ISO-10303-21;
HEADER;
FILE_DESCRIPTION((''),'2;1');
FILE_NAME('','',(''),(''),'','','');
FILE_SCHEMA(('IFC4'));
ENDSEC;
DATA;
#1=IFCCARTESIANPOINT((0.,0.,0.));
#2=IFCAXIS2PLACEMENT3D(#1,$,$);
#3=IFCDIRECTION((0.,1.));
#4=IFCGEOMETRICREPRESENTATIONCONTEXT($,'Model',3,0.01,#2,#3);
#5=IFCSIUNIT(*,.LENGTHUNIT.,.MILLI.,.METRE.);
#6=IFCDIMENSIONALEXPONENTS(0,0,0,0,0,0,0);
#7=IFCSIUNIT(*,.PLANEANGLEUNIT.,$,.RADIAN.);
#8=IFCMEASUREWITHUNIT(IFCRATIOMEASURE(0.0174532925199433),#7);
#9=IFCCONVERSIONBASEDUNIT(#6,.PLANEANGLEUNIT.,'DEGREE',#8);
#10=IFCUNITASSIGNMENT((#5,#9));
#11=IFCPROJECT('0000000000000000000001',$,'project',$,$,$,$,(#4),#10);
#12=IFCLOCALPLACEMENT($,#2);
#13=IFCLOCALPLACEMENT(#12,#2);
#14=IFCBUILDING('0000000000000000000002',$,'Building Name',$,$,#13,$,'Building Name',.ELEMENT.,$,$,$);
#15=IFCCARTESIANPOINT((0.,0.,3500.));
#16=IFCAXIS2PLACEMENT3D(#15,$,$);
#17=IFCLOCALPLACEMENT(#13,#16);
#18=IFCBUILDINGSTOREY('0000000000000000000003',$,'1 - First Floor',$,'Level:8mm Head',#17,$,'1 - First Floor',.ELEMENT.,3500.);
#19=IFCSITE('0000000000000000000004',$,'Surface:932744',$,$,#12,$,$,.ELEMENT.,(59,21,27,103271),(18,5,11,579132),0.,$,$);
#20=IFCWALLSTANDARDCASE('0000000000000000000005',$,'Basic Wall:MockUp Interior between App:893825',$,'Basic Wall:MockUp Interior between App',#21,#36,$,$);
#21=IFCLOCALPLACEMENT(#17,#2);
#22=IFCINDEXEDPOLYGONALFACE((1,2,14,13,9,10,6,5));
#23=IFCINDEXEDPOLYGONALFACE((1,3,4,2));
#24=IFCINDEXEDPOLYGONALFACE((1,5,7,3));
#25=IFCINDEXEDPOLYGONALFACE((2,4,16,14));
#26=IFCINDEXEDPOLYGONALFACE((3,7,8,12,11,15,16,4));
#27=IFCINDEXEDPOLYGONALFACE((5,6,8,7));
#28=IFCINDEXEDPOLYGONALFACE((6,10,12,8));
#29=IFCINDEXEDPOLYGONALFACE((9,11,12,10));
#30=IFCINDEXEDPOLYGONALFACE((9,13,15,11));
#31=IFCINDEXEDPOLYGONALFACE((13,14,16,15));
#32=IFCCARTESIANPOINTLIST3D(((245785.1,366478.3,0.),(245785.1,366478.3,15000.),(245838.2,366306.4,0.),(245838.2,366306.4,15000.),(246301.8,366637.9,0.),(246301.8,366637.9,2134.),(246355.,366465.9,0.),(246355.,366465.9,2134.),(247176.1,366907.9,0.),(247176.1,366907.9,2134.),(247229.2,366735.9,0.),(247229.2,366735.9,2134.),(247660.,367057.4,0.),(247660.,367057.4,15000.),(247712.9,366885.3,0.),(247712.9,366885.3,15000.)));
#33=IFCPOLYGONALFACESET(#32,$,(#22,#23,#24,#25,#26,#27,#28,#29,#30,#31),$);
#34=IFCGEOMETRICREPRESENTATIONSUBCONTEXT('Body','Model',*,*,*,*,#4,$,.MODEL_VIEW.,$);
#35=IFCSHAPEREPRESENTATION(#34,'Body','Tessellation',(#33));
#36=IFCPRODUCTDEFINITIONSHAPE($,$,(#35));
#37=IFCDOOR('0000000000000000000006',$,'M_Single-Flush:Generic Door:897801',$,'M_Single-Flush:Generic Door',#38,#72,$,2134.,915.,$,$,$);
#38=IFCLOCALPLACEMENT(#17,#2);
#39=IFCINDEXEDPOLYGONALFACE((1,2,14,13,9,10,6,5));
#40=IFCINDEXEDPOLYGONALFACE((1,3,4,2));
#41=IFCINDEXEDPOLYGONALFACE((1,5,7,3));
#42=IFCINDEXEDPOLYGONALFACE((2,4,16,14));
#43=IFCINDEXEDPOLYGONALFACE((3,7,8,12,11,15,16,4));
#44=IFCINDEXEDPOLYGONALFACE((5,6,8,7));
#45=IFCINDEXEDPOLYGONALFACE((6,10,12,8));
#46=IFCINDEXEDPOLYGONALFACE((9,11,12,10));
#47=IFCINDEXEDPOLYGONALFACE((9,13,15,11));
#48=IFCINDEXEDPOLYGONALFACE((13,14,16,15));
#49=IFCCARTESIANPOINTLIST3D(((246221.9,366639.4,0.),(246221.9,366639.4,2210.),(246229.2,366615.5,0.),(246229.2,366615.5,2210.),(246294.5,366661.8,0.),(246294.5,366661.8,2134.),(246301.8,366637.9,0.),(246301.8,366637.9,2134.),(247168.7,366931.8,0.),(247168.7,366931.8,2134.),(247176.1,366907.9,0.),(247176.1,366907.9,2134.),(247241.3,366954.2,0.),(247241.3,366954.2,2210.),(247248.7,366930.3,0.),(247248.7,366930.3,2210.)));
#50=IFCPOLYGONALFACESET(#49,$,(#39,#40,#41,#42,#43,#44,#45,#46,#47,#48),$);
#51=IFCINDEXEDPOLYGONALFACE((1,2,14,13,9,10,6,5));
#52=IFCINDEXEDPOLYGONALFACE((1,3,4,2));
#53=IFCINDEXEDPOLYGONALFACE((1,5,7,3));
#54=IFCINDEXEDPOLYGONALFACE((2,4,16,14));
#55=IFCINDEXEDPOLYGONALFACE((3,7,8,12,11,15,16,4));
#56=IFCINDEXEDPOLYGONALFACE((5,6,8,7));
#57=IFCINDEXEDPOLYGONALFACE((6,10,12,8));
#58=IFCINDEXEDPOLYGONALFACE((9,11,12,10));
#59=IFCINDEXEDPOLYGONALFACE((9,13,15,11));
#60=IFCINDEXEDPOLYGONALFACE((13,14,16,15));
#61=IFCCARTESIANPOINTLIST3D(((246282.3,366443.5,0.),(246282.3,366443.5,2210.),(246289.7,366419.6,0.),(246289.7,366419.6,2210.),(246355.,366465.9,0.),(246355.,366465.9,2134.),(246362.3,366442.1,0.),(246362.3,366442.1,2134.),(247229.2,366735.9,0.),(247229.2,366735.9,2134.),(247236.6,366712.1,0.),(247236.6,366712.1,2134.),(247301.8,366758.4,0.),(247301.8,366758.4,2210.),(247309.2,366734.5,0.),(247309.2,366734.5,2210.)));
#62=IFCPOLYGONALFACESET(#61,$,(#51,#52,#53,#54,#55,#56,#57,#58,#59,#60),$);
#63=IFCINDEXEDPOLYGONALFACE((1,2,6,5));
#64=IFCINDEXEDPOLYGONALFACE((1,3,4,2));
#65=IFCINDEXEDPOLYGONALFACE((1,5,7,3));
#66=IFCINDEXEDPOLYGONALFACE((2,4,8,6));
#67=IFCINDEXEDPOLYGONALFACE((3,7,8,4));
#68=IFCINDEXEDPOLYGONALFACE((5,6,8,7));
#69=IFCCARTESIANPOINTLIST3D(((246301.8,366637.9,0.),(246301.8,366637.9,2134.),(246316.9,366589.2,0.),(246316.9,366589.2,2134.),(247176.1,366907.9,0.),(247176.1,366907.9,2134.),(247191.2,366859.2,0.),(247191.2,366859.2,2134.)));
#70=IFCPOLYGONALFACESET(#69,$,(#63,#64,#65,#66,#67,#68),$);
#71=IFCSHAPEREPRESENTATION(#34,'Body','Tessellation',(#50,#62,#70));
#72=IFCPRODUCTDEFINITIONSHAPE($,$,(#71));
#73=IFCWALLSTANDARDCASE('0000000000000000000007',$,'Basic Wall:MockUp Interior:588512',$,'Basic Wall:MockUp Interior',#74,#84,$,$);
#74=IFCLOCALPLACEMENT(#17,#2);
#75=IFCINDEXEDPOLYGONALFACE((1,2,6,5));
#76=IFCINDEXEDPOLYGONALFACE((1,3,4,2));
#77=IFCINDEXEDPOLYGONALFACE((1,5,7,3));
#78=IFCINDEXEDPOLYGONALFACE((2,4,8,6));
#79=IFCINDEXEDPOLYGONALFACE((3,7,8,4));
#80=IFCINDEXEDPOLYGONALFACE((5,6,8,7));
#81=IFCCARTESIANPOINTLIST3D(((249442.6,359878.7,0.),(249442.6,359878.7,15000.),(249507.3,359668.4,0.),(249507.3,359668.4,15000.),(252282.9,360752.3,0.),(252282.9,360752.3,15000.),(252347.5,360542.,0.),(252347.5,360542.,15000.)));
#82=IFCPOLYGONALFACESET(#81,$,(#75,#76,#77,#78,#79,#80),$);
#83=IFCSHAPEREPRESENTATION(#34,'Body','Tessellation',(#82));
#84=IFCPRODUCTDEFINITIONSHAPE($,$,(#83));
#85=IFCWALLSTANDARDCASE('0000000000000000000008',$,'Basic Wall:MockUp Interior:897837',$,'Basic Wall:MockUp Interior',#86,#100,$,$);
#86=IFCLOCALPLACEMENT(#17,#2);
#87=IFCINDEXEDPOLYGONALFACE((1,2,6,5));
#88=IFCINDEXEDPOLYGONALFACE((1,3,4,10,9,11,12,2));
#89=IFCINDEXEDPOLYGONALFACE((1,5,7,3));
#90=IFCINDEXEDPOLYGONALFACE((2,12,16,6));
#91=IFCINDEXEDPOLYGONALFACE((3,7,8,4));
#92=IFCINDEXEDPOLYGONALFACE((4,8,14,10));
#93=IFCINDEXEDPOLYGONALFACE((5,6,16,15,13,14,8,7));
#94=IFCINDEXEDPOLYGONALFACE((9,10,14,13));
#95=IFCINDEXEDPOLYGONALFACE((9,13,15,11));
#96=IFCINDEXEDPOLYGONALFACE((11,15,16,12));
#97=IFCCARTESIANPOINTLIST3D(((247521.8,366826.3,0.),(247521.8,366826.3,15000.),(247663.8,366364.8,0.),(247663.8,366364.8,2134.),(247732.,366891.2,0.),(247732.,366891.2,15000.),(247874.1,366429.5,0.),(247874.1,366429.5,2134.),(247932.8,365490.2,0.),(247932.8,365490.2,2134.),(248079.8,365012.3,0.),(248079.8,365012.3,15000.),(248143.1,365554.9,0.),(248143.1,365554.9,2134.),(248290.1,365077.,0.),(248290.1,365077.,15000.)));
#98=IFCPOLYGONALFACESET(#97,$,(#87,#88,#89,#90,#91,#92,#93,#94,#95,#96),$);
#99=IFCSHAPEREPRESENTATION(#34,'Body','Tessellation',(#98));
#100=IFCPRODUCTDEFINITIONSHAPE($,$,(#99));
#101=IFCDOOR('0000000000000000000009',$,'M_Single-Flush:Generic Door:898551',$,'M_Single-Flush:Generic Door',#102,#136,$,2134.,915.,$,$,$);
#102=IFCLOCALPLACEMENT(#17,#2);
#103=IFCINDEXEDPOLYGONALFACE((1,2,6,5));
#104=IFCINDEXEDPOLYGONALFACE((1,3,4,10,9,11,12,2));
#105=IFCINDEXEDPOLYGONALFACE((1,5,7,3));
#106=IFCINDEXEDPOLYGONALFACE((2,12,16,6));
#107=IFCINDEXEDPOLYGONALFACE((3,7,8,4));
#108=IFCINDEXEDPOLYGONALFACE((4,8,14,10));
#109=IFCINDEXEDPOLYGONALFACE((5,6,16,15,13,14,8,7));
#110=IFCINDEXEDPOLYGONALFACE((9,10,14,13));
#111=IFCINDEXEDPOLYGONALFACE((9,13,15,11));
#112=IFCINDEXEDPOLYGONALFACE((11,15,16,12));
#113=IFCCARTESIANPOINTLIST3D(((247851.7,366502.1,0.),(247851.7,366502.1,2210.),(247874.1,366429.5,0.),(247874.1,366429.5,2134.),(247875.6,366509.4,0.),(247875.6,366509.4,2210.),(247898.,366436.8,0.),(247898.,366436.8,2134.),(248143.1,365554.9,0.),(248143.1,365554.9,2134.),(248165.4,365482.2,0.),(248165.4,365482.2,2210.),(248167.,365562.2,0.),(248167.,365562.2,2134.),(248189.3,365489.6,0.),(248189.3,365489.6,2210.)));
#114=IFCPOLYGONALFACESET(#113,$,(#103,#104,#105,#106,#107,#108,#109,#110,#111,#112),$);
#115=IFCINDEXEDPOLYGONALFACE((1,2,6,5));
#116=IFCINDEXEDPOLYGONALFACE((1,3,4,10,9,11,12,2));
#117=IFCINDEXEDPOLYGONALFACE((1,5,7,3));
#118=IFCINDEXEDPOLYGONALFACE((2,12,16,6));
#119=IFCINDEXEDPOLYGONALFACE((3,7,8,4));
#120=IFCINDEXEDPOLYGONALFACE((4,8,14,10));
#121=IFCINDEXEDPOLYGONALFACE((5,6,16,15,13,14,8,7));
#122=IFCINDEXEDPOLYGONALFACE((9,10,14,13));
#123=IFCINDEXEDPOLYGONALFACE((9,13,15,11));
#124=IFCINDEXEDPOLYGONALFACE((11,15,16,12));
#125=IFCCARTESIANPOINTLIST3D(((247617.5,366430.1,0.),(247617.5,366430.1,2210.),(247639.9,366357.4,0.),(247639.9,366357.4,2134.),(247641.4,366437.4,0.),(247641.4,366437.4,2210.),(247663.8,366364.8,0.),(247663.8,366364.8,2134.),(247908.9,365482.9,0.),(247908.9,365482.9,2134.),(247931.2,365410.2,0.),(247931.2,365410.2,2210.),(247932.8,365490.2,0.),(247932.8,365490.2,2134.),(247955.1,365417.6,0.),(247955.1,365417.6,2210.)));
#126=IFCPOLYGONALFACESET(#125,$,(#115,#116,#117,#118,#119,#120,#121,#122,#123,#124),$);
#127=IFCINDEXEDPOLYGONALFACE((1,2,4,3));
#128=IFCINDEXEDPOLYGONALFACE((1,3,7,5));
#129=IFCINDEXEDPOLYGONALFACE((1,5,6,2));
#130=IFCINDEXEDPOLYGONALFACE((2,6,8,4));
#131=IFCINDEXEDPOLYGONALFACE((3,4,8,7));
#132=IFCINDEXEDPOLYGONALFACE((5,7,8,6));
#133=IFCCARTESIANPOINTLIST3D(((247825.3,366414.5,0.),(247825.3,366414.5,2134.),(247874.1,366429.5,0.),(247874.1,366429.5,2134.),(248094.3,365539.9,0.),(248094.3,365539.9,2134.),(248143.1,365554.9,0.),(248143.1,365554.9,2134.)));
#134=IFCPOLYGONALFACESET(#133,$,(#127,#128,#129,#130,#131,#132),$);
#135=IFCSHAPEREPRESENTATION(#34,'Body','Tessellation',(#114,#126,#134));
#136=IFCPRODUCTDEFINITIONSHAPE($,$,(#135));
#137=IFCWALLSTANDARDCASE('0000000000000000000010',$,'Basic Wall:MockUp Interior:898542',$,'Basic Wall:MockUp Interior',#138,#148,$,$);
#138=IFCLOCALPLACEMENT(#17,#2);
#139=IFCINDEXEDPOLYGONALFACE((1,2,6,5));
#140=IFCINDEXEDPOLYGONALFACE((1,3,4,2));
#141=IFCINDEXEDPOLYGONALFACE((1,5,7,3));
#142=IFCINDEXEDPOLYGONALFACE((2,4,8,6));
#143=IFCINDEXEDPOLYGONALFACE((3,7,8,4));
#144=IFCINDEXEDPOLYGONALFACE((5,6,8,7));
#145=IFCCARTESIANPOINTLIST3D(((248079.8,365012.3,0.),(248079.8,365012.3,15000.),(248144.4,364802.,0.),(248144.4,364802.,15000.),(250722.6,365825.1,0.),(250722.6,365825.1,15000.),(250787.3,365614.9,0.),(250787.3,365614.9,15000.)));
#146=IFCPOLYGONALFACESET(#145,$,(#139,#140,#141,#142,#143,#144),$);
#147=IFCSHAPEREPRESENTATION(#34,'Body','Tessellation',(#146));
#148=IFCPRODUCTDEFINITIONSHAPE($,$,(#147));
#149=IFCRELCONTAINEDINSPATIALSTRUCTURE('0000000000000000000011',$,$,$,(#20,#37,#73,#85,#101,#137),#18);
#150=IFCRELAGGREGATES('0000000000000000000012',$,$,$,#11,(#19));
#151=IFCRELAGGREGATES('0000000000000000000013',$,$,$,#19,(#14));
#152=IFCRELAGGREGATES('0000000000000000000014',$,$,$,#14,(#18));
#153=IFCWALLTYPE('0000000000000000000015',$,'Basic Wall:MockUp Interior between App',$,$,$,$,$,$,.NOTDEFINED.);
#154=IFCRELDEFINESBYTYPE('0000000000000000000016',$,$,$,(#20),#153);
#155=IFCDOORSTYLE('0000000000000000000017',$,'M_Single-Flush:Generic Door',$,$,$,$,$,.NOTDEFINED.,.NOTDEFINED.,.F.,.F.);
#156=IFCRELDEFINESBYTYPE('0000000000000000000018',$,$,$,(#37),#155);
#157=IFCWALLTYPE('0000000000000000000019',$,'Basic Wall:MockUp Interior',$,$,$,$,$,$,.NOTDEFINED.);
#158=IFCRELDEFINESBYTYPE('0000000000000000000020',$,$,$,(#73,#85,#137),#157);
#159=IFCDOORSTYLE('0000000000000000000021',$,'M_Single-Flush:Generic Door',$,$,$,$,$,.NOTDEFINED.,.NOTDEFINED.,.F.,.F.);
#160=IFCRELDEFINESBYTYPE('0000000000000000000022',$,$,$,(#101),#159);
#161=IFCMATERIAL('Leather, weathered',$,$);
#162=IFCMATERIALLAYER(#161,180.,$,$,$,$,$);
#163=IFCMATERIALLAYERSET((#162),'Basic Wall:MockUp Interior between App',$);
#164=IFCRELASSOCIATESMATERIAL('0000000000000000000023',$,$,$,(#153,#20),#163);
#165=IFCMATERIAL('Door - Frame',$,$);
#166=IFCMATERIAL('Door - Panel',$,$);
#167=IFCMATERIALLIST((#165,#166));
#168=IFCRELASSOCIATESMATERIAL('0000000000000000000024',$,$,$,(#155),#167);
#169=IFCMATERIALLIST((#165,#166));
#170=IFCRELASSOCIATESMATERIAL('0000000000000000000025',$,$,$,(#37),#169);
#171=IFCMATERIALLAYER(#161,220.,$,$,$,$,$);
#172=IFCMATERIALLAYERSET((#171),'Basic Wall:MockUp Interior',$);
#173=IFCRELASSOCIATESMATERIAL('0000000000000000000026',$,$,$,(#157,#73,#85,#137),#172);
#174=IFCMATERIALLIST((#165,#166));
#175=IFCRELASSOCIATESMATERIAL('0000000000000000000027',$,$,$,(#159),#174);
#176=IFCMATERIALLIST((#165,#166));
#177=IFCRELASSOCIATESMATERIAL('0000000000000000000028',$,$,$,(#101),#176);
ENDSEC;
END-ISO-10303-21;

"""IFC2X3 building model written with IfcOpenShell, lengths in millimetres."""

from ifc_helpers import new_model, entity, si_unit, converted_unit, direction, frame, frame_2d, origin, place, context, subcontext, project, spatial, polyline, rectangle, outline, extrude, source, transform, mapped, material, material_list, layer, layer_set, layer_usage, type_object, type_shapes, element, fill, save


model = new_model("IFC2X3")

# Units and contexts
model_context = context("Model", 3, precision=0.01, world=origin(), true_north=direction((0.0, 1.0)))
body_context = subcontext(model_context, "Body", "Model", "MODEL_VIEW")
ifc_project = project(units=[si_unit("LENGTHUNIT", "METRE", prefix="MILLI"), converted_unit("PLANEANGLEUNIT", "DEGREE", entity("IfcRatioMeasure", 0.0174532925199433), si_unit("PLANEANGLEUNIT", "RADIAN"), dimensions=[0, 0, 0, 0, 0, 0, 0])], contexts=[model_context])

# Site, building, storey
site_placement = place(None, origin())
site = spatial("IfcSite", under=ifc_project, at=site_placement, Name="Surface:932744", CompositionType="ELEMENT", RefLatitude=(59, 21, 27, 103271), RefLongitude=(18, 5, 11, 579132), RefElevation=0.0)
building_placement = place(site_placement, origin())
building = spatial("IfcBuilding", under=site, at=building_placement, Name="Building Name", LongName="Building Name", CompositionType="ELEMENT")
storey_placement = place(building_placement, frame((0.0, 0.0, 3500.0)))
storey = spatial("IfcBuildingStorey", under=building, at=storey_placement, Name="1 - First Floor", ObjectType="Level:8mm Head", LongName="1 - First Floor", CompositionType="ELEMENT", Elevation=3500.0)

# Wall, opening, door
ifc_material_1 = material(Name="Leather, weathered")
ifc_layer_1 = layer(ifc_material_1, 180.0)
ifc_layer_set_1 = layer_set([ifc_layer_1], Name="Basic Wall:MockUp Interior between App")
ifc_layer_usage_1 = layer_usage(ifc_layer_set_1, "AXIS2", "NEGATIVE", 90.0)
wall_type_1 = type_object("IfcWallType", Name="Basic Wall:MockUp Interior between App", PredefinedType="NOTDEFINED", material=ifc_layer_set_1)
wall_1_placement = place(storey_placement, frame((245811.7, 366392.3, 0.0), z_axis=(0.0, 0.0, 1.0), x_axis=(0.955473, 0.29508, 0.0)))
wall_1 = element("IfcWallStandardCase", 1, at=wall_1_placement, inside=storey, type_object=wall_type_1, material=ifc_layer_usage_1, Name="Basic Wall:MockUp Interior between App:893825", ObjectType="Basic Wall:MockUp Interior between App", context=body_context, shape_type="SweptSolid", body=[
    extrude(outline(polyline([(0.0, -90.0), (1762.1, -90.0), (1962.1, -90.0), (1962.3, 90.0), (1782.3, 90.0), (0.0, 90.0), (0.0, -90.0)])), origin(), (0.0, 0.0, 1.0), 15000.0),
])
opening_1_placement = place(wall_1_placement, frame((540.8, -90.0, 0.0)))
opening_1 = element("IfcOpeningElement", 2, at=opening_1_placement, cuts=wall_1, ObjectType="Opening", context=body_context, shape_type="SweptSolid", body=[
    extrude(rectangle(XDim=915.0, YDim=2134.0, at=frame_2d((1067.0, 457.5), x_axis=(0.0, 1.0))), frame((0.0, 0.0, 0.0), z_axis=(0.0, 1.0, 0.0), x_axis=(0.0, 0.0, 1.0)), (0.0, 0.0, 1.0), 180.0),
])
ifc_material_2 = material(Name="Door - Frame")
ifc_material_3 = material(Name="Door - Panel")
ifc_material_list_1 = material_list([ifc_material_2, ifc_material_3])
ifc_material_list_2 = material_list([ifc_material_2, ifc_material_3])
door_style_1 = type_object("IfcDoorStyle", Name="M_Single-Flush:Generic Door", ConstructionType="NOTDEFINED", OperationType="NOTDEFINED", ParameterTakesPrecedence=False, Sizeable=False, material=ifc_material_list_2)
shared_shape_1 = source(origin(), body_context, "Body", "SweptSolid", [
    extrude(outline(polyline([(-533.5, -1124.0), (533.5, -1124.0), (533.5, 1086.0), (457.5, 1086.0), (457.5, -1048.0), (-457.5, -1048.0), (-457.5, 1086.0), (-533.5, 1086.0), (-533.5, -1124.0)])), frame((457.5, 180.0, 1086.0), z_axis=(0.0, 1.0, 0.0), x_axis=(1.0, 0.0, 0.0)), (0.0, 0.0, 1.0), 25.0),
    extrude(outline(polyline([(-1124.0, -533.5), (1086.0, -533.5), (1086.0, -457.5), (-1048.0, -457.5), (-1048.0, 457.5), (1086.0, 457.5), (1086.0, 533.5), (-1124.0, 533.5), (-1124.0, -533.5)])), frame((457.5, -25.0, 1086.0), z_axis=(0.0, 1.0, 0.0), x_axis=(0.0, 0.0, -1.0)), (0.0, 0.0, 1.0), 25.0),
    extrude(rectangle(XDim=51.0, YDim=915.0, at=frame_2d((0.0, 0.0), x_axis=(1.0, 0.0))), frame((457.5, 154.5, 0.0), z_axis=(0.0, 0.0, 1.0), x_axis=(0.0, 1.0, 0.0)), (0.0, 0.0, 1.0), 2134.0),
])
type_shapes(door_style_1, [shared_shape_1])
door_1_placement = place(opening_1_placement, origin())
door_1 = element("IfcDoor", 3, at=door_1_placement, inside=storey, type_object=door_style_1, material=ifc_material_list_1, Name="M_Single-Flush:Generic Door:897801", ObjectType="M_Single-Flush:Generic Door", OverallHeight=2134.0, OverallWidth=915.0, context=body_context, shape_type="MappedRepresentation", body=[
    mapped(shared_shape_1, transform((0.0, 0.0, 0.0), scale=1.0)),
])
fill(opening_1, door_1)

# Wall
ifc_layer_2 = layer(ifc_material_1, 220.0)
ifc_layer_set_2 = layer_set([ifc_layer_2], Name="Basic Wall:MockUp Interior")
ifc_layer_usage_2 = layer_usage(ifc_layer_set_2, "AXIS2", "NEGATIVE", 110.0)
wall_type_2 = type_object("IfcWallType", Name="Basic Wall:MockUp Interior", PredefinedType="NOTDEFINED", material=ifc_layer_set_2)
wall_2_placement = place(storey_placement, frame((249475.0, 359773.6, 0.0), z_axis=(0.0, 0.0, 1.0), x_axis=(0.955811, 0.29398, 0.0)))
element("IfcWallStandardCase", 4, at=wall_2_placement, inside=storey, type_object=wall_type_2, material=ifc_layer_usage_2, Name="Basic Wall:MockUp Interior:588512", ObjectType="Basic Wall:MockUp Interior", context=body_context, shape_type="SweptSolid", body=[
    extrude(rectangle(XDim=2971.5, YDim=220.0, at=frame_2d((1485.8, 0.0), x_axis=(-1.0, 0.0))), origin(), (0.0, 0.0, 1.0), 15000.0),
])

# Wall, opening, door
ifc_layer_usage_3 = layer_usage(ifc_layer_set_2, "AXIS2", "NEGATIVE", 110.0)
wall_3_placement = place(storey_placement, frame((247626.9, 366858.9, 0.0), z_axis=(0.0, 0.0, 1.0), x_axis=(0.29398, -0.955811, 0.0)))
wall_3 = element("IfcWallStandardCase", 5, at=wall_3_placement, inside=storey, type_object=wall_type_2, material=ifc_layer_usage_3, Name="Basic Wall:MockUp Interior:897837", ObjectType="Basic Wall:MockUp Interior", context=body_context, shape_type="SweptSolid", body=[
    extrude(outline(polyline([(0.3, -110.0), (1898.1, -110.0), (1898.1, 110.0), (0.0, 110.0), (0.0, 90.0), (0.3, -110.0)])), origin(), (0.0, 0.0, 1.0), 15000.0),
])
opening_2_placement = place(wall_3_placement, frame((483.1, -110.0, 0.0)))
opening_2 = element("IfcOpeningElement", 6, at=opening_2_placement, cuts=wall_3, ObjectType="Opening", context=body_context, shape_type="SweptSolid", body=[
    extrude(rectangle(XDim=915.0, YDim=2134.0, at=frame_2d((1067.0, 457.5), x_axis=(0.0, 1.0))), frame((0.0, 0.0, 0.0), z_axis=(0.0, 1.0, 0.0), x_axis=(0.0, 0.0, 1.0)), (0.0, 0.0, 1.0), 220.0),
])
ifc_material_list_3 = material_list([ifc_material_2, ifc_material_3])
ifc_material_list_4 = material_list([ifc_material_2, ifc_material_3])
door_style_2 = type_object("IfcDoorStyle", Name="M_Single-Flush:Generic Door", ConstructionType="NOTDEFINED", OperationType="NOTDEFINED", ParameterTakesPrecedence=False, Sizeable=False, material=ifc_material_list_4)
shared_shape_2 = source(origin(), body_context, "Body", "SweptSolid", [
    extrude(outline(polyline([(-533.5, -1124.0), (533.5, -1124.0), (533.5, 1086.0), (457.5, 1086.0), (457.5, -1048.0), (-457.5, -1048.0), (-457.5, 1086.0), (-533.5, 1086.0), (-533.5, -1124.0)])), frame((457.5, 220.0, 1086.0), z_axis=(0.0, 1.0, 0.0), x_axis=(1.0, 0.0, 0.0)), (0.0, 0.0, 1.0), 25.0),
    extrude(outline(polyline([(-1124.0, -533.5), (1086.0, -533.5), (1086.0, -457.5), (-1048.0, -457.5), (-1048.0, 457.5), (1086.0, 457.5), (1086.0, 533.5), (-1124.0, 533.5), (-1124.0, -533.5)])), frame((457.5, -25.0, 1086.0), z_axis=(0.0, 1.0, 0.0), x_axis=(0.0, 0.0, -1.0)), (0.0, 0.0, 1.0), 25.0),
    extrude(rectangle(XDim=51.0, YDim=915.0, at=frame_2d((0.0, 0.0), x_axis=(1.0, 0.0))), frame((457.5, 194.5, 0.0), z_axis=(0.0, 0.0, 1.0), x_axis=(0.0, 1.0, 0.0)), (0.0, 0.0, 1.0), 2134.0),
])
type_shapes(door_style_2, [shared_shape_2])
door_2_placement = place(opening_2_placement, origin())
door_2 = element("IfcDoor", 7, at=door_2_placement, inside=storey, type_object=door_style_2, material=ifc_material_list_3, Name="M_Single-Flush:Generic Door:898551", ObjectType="M_Single-Flush:Generic Door", OverallHeight=2134.0, OverallWidth=915.0, context=body_context, shape_type="MappedRepresentation", body=[
    mapped(shared_shape_2, transform((0.0, 0.0, 0.0), scale=1.0)),
])
fill(opening_2, door_2)

# Wall
ifc_layer_usage_4 = layer_usage(ifc_layer_set_2, "AXIS2", "NEGATIVE", 110.0)
wall_4_placement = place(storey_placement, frame((248112.1, 364907.2, 0.0), z_axis=(0.0, 0.0, 1.0), x_axis=(0.955811, 0.29398, 0.0)))
element("IfcWallStandardCase", 8, at=wall_4_placement, inside=storey, type_object=wall_type_2, material=ifc_layer_usage_4, Name="Basic Wall:MockUp Interior:898542", ObjectType="Basic Wall:MockUp Interior", context=body_context, shape_type="SweptSolid", body=[
    extrude(rectangle(XDim=2765.0, YDim=220.0, at=frame_2d((1382.5, 0.0), x_axis=(-1.0, 0.0))), origin(), (0.0, 0.0, 1.0), 15000.0),
])

save(model, "model.ifc")
